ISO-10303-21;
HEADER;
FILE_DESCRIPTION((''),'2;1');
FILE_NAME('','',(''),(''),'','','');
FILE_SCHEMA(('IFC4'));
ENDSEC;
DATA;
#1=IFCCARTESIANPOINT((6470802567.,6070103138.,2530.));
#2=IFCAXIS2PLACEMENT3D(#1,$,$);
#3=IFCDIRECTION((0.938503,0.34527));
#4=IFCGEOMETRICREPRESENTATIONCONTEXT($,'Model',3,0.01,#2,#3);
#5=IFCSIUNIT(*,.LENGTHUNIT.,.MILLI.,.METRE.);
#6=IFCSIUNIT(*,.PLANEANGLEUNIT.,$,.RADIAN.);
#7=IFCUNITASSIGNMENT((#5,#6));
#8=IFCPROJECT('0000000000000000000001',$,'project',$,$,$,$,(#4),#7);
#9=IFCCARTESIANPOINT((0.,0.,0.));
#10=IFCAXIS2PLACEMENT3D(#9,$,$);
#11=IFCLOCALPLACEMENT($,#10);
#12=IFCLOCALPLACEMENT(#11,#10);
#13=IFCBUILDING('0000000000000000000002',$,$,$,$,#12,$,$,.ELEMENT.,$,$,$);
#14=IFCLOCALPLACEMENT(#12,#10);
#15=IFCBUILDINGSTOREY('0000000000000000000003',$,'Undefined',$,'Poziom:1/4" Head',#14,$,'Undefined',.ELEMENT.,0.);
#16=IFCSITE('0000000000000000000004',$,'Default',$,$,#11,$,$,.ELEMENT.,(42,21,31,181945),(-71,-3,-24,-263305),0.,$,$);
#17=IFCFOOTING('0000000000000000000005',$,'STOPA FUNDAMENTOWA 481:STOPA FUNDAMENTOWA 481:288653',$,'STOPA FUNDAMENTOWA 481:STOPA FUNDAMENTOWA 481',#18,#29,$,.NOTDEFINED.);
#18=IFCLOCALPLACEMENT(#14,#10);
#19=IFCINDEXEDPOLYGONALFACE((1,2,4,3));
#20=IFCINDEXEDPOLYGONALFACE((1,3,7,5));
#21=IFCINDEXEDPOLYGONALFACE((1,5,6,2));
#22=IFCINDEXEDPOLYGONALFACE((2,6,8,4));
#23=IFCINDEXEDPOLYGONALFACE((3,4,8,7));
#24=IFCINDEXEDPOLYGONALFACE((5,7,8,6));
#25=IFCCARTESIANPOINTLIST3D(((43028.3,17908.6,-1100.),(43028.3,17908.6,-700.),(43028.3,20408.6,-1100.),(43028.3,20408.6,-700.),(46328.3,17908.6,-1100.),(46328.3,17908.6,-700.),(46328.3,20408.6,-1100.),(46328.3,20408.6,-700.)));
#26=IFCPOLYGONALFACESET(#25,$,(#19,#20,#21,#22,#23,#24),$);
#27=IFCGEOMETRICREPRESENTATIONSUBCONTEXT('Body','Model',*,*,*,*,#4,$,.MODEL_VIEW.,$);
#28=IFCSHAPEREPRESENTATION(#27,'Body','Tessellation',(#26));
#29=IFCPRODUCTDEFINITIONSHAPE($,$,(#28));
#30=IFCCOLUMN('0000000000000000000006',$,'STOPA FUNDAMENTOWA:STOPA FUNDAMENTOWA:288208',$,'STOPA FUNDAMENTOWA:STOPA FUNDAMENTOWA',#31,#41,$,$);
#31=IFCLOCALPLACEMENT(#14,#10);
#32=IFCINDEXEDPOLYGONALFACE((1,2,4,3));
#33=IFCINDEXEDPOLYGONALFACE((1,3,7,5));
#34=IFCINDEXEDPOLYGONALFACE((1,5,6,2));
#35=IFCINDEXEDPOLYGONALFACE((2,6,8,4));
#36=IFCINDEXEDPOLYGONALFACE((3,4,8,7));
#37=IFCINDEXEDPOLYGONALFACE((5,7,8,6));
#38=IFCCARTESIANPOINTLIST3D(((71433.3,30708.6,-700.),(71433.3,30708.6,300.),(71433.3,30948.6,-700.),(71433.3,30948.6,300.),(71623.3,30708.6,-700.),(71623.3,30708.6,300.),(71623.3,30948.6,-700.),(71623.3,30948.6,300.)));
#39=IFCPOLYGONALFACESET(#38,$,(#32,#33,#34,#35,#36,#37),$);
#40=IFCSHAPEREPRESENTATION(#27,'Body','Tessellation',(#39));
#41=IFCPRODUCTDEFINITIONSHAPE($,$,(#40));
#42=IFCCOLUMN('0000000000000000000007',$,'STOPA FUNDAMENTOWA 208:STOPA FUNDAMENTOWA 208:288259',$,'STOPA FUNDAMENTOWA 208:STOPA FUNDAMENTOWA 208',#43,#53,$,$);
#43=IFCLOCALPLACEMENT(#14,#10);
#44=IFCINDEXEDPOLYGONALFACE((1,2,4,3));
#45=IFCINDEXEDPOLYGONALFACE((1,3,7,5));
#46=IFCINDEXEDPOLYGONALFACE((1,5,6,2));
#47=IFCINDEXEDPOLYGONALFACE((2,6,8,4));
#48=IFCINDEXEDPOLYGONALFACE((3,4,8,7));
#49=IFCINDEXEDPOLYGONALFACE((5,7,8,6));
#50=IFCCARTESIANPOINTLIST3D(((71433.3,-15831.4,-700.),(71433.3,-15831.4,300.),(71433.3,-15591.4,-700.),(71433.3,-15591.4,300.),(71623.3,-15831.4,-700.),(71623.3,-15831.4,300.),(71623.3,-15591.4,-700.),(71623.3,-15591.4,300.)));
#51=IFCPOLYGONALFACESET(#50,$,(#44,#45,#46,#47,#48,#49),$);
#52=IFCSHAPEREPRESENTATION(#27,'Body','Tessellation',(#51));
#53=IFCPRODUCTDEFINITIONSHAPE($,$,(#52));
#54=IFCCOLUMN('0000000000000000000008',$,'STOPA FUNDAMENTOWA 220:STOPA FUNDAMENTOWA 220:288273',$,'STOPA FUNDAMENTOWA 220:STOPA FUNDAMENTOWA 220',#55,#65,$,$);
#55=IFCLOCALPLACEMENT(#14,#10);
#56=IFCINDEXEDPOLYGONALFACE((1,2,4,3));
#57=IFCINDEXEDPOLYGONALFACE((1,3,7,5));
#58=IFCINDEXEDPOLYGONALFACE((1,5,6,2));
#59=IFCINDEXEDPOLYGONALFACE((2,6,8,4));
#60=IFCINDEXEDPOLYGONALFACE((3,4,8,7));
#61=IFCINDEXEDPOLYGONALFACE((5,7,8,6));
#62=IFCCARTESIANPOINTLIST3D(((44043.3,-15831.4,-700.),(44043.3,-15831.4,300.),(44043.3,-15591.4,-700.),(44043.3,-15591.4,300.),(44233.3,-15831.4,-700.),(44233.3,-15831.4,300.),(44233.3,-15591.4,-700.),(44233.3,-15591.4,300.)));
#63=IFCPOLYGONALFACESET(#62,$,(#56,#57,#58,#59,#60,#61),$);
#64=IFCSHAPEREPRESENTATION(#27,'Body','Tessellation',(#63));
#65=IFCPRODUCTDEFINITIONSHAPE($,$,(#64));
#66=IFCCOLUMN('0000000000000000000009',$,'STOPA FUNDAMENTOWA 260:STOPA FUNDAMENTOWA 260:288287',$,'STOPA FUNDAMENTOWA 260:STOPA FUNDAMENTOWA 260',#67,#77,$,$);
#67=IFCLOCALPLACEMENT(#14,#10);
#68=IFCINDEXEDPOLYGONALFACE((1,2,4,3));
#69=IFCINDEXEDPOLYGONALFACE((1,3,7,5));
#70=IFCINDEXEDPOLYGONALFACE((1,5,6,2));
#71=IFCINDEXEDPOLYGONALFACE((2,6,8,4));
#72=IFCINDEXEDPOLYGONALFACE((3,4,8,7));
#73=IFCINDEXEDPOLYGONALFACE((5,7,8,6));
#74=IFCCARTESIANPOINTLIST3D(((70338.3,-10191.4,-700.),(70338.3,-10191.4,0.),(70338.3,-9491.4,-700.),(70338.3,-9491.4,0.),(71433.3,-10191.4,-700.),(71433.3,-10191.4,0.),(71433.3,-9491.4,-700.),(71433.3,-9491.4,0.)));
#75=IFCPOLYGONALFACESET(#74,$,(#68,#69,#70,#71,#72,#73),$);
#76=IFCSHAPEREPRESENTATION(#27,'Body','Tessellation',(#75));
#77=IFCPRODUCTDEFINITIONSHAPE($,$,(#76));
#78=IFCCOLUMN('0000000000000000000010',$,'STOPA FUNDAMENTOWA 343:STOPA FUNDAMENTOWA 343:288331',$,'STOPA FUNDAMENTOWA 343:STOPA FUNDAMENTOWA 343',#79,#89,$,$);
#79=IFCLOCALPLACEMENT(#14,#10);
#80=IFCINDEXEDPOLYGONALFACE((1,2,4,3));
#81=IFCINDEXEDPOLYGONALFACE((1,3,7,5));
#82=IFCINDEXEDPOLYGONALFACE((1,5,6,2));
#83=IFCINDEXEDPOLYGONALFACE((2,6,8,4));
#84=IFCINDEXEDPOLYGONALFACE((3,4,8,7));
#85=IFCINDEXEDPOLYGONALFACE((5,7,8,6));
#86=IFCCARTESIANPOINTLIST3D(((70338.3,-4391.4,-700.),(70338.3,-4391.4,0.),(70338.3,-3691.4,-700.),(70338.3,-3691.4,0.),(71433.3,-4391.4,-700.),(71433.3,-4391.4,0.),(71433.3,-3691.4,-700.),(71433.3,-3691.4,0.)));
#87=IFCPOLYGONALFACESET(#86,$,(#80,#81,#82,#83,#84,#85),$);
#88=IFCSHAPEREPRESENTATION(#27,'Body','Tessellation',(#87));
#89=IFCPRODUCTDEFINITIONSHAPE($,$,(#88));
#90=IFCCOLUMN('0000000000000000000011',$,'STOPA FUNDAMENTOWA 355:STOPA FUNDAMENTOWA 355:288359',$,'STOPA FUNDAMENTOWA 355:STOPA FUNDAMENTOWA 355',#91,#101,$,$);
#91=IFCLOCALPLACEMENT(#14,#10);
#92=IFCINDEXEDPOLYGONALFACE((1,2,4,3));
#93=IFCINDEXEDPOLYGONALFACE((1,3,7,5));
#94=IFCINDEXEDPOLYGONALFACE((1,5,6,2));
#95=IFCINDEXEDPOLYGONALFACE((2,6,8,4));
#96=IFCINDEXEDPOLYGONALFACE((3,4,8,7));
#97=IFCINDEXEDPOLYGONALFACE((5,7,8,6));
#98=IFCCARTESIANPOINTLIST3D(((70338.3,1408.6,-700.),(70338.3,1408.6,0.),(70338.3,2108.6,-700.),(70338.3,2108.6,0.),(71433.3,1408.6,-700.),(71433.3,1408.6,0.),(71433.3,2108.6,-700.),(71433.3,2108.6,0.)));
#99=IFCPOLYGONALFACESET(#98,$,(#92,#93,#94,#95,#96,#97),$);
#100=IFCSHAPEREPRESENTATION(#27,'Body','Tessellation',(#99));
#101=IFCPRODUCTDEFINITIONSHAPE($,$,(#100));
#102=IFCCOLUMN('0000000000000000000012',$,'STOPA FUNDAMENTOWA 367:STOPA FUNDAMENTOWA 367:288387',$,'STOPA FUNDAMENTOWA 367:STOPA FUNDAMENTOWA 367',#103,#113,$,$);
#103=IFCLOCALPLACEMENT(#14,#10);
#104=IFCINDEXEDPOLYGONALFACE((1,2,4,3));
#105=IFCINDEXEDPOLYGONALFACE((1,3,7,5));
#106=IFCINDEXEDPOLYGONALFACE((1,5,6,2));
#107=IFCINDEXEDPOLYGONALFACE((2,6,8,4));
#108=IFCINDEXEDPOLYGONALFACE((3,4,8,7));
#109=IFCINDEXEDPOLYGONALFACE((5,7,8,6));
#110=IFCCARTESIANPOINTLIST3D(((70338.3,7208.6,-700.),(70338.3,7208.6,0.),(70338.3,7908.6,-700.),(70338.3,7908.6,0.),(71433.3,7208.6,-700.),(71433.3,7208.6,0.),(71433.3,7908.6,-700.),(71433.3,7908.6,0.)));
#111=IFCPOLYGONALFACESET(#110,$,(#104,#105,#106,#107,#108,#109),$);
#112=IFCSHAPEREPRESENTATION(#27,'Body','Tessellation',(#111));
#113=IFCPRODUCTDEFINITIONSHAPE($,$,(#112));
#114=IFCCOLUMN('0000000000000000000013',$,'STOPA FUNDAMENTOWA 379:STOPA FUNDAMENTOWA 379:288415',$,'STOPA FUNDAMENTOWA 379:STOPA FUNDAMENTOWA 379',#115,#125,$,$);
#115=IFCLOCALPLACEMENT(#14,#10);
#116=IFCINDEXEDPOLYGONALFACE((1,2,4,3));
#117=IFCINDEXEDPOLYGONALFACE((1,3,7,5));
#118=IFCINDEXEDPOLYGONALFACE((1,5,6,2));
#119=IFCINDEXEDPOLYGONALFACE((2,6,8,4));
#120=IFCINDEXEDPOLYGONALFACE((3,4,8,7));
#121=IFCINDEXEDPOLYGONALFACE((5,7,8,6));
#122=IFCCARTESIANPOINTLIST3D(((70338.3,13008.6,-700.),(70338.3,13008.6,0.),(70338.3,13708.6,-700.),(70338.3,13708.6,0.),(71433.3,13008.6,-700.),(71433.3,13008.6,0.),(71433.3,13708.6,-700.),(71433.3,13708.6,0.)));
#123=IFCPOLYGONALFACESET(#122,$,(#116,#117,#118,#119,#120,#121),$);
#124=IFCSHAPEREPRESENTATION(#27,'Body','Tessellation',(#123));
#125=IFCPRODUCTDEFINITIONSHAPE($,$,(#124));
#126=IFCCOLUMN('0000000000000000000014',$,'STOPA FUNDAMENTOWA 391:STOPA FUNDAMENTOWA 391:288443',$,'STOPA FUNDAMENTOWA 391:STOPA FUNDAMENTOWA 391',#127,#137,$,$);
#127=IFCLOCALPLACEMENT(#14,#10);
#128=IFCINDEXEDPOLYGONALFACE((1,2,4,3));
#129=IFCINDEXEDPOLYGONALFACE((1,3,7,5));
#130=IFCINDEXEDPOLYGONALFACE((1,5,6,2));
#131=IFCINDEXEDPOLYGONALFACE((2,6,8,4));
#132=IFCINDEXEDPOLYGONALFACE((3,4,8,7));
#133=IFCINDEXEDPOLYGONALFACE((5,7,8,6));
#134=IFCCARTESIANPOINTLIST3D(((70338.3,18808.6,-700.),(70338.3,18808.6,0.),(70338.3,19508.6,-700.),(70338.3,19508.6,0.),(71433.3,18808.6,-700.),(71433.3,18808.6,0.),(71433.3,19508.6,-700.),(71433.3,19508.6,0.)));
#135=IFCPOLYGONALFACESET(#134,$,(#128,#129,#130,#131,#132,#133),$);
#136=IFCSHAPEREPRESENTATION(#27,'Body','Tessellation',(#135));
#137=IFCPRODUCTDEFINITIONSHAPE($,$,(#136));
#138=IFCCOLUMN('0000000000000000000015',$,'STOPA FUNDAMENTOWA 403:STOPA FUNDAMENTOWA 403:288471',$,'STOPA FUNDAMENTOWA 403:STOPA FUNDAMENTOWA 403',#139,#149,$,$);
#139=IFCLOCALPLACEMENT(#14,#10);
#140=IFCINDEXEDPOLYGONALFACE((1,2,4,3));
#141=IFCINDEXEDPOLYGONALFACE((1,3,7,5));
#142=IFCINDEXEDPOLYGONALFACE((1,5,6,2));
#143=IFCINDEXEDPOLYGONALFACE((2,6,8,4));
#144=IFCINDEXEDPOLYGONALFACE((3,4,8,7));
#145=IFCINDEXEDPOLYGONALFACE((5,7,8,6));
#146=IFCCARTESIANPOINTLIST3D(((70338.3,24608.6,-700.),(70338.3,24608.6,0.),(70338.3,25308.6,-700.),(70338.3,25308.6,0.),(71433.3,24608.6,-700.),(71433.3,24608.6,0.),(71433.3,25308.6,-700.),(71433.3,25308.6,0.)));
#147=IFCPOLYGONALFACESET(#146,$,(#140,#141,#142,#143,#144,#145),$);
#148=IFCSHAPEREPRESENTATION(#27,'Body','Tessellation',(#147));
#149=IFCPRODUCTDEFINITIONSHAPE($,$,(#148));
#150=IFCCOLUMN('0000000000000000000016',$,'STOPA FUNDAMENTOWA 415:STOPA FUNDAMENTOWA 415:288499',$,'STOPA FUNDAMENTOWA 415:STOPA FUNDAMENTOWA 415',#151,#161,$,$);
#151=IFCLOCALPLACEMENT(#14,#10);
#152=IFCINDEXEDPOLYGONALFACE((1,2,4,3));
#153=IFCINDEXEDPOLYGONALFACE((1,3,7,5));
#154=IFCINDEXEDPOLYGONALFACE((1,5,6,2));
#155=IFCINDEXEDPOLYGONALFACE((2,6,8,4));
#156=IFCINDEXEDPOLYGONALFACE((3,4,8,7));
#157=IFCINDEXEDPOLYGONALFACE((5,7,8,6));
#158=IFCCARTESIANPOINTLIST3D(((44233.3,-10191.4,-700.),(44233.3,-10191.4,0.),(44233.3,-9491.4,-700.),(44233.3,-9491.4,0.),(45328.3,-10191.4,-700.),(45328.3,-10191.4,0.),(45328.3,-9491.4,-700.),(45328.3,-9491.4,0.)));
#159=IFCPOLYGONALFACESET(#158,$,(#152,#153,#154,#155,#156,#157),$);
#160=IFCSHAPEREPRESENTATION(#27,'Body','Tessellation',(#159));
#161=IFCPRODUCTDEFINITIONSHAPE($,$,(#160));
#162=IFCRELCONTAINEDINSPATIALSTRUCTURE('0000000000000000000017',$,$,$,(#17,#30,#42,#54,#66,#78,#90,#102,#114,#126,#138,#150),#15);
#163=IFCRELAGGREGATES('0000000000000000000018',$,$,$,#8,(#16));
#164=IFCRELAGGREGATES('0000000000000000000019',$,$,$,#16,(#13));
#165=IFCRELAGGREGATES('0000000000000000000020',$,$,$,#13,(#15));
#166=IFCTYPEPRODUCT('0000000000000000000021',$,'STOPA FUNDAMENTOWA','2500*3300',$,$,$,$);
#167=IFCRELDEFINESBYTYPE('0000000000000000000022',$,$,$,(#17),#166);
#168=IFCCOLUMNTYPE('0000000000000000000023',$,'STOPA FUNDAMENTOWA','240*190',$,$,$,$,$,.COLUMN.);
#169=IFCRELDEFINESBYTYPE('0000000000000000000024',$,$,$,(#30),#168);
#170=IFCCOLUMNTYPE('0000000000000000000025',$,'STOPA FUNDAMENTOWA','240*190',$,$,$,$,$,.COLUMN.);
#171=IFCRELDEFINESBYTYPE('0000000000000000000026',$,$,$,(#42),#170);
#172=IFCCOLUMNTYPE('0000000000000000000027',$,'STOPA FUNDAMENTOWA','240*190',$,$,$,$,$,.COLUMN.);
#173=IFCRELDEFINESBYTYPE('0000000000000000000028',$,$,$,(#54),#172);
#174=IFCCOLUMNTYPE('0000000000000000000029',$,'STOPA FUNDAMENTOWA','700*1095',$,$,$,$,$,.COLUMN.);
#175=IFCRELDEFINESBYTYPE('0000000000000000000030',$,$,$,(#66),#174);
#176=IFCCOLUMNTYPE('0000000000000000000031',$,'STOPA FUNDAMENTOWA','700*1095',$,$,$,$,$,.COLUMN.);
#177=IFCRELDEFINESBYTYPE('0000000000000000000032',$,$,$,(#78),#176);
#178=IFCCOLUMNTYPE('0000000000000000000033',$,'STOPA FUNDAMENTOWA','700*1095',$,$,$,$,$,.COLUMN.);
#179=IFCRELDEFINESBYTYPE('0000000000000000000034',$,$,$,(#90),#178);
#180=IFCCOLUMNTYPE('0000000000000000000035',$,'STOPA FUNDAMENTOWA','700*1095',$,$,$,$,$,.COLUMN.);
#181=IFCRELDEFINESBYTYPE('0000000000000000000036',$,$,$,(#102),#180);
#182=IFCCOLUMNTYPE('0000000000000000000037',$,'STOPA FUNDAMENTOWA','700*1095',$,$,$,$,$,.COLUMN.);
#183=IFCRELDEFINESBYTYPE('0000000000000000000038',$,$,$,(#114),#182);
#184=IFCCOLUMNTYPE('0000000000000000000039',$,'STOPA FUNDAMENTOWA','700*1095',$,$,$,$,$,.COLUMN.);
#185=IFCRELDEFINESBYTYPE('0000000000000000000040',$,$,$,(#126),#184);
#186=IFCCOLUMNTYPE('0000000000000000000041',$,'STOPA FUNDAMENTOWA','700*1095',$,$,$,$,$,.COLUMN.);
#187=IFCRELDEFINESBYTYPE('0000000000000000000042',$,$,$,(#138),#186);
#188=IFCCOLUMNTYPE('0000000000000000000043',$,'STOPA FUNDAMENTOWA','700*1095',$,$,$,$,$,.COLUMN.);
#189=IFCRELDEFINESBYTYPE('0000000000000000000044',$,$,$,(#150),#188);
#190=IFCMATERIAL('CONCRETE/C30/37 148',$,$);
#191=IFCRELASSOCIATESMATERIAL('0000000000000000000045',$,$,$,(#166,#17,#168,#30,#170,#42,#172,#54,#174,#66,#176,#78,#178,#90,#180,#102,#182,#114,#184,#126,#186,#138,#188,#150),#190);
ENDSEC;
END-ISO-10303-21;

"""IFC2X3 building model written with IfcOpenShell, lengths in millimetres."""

from ifc_helpers import new_model, si_unit, direction, frame, frame_2d, origin, origin_2d_with_axis, place, context, subcontext, project, spatial, rectangle, extrude, source, transform, mapped, material, type_object, type_shapes, element, save


model = new_model("IFC2X3")

# Units and contexts
model_context = context("Model", 3, precision=0.01, world=frame((6470802567.0, 6070103138.0, 2530.0)), true_north=direction((0.938503, 0.34527)))
body_context = subcontext(model_context, "Body", "Model", "MODEL_VIEW")
ifc_project = project(units=[si_unit("LENGTHUNIT", "METRE", prefix="MILLI"), si_unit("PLANEANGLEUNIT", "RADIAN")], contexts=[model_context])

# Site, building, storey
site_placement = place(None, origin())
site = spatial("IfcSite", under=ifc_project, at=site_placement, Name="Default", CompositionType="ELEMENT", RefLatitude=(42, 21, 31, 181945), RefLongitude=(-71, -3, -24, -263305), RefElevation=0.0)
building_placement = place(site_placement, origin())
building = spatial("IfcBuilding", under=site, at=building_placement, CompositionType="ELEMENT")
storey_placement = place(building_placement, origin())
storey = spatial("IfcBuildingStorey", under=building, at=storey_placement, Name="Undefined", ObjectType="Poziom:1/4\" Head", LongName="Undefined", CompositionType="ELEMENT", Elevation=0.0)

# Footing
ifc_material = material(Name="CONCRETE/C30/37 148")
type_product_1 = type_object("IfcTypeProduct", Name="STOPA FUNDAMENTOWA", Description="2500*3300", material=ifc_material)
shared_shape_1 = source(origin(), body_context, "Body", "SweptSolid", [
    extrude(rectangle(XDim=2500.0, YDim=3300.0, at=origin_2d_with_axis()), frame((44678.3, 19158.6, -1100.0), z_axis=(0.0, 0.0, 1.0), x_axis=(0.0, -1.0, 0.0)), (0.0, 0.0, 1.0), 400.0),
])
type_shapes(type_product_1, [shared_shape_1])
footing_1_placement = place(storey_placement, origin())
element("IfcFooting", 1, at=footing_1_placement, inside=storey, type_object=type_product_1, material=ifc_material, Name="STOPA FUNDAMENTOWA 481:STOPA FUNDAMENTOWA 481:288653", ObjectType="STOPA FUNDAMENTOWA 481:STOPA FUNDAMENTOWA 481", PredefinedType="NOTDEFINED", context=body_context, shape_type="MappedRepresentation", body=[
    mapped(shared_shape_1, transform((0.0, 0.0, 0.0), scale=1.0)),
])

# Columns
column_type_1 = type_object("IfcColumnType", Name="STOPA FUNDAMENTOWA", Description="240*190", PredefinedType="COLUMN", material=ifc_material)
shared_shape_2 = source(origin(), body_context, "Body", "SweptSolid", [
    extrude(rectangle(XDim=240.0, YDim=190.0, at=frame_2d((0.0, 0.0), x_axis=(1.0, 0.0))), frame((71528.3, 30828.6, -700.0), z_axis=(0.0, 0.0, 1.0), x_axis=(0.0, -1.0, 0.0)), (0.0, 0.0, 1.0), 1000.0),
])
type_shapes(column_type_1, [shared_shape_2])
column_1_placement = place(storey_placement, origin())
element("IfcColumn", 2, at=column_1_placement, inside=storey, type_object=column_type_1, material=ifc_material, Name="STOPA FUNDAMENTOWA:STOPA FUNDAMENTOWA:288208", ObjectType="STOPA FUNDAMENTOWA:STOPA FUNDAMENTOWA", context=body_context, shape_type="MappedRepresentation", body=[
    mapped(shared_shape_2, transform((0.0, 0.0, 0.0), scale=1.0)),
])
column_type_2 = type_object("IfcColumnType", Name="STOPA FUNDAMENTOWA", Description="240*190", PredefinedType="COLUMN", material=ifc_material)
shared_shape_3 = source(origin(), body_context, "Body", "SweptSolid", [
    extrude(rectangle(XDim=240.0, YDim=190.0, at=frame_2d((0.0, 0.0), x_axis=(1.0, 0.0))), frame((71528.3, -15711.4, -700.0), z_axis=(0.0, 0.0, 1.0), x_axis=(0.0, -1.0, 0.0)), (0.0, 0.0, 1.0), 1000.0),
])
type_shapes(column_type_2, [shared_shape_3])
column_2_placement = place(storey_placement, origin())
element("IfcColumn", 3, at=column_2_placement, inside=storey, type_object=column_type_2, material=ifc_material, Name="STOPA FUNDAMENTOWA 208:STOPA FUNDAMENTOWA 208:288259", ObjectType="STOPA FUNDAMENTOWA 208:STOPA FUNDAMENTOWA 208", context=body_context, shape_type="MappedRepresentation", body=[
    mapped(shared_shape_3, transform((0.0, 0.0, 0.0), scale=1.0)),
])
column_type_3 = type_object("IfcColumnType", Name="STOPA FUNDAMENTOWA", Description="240*190", PredefinedType="COLUMN", material=ifc_material)
shared_shape_4 = source(origin(), body_context, "Body", "SweptSolid", [
    extrude(rectangle(XDim=240.0, YDim=190.0, at=frame_2d((0.0, 0.0), x_axis=(1.0, 0.0))), frame((44138.3, -15711.4, -700.0), z_axis=(0.0, 0.0, 1.0), x_axis=(0.0, 1.0, 0.0)), (0.0, 0.0, 1.0), 1000.0),
])
type_shapes(column_type_3, [shared_shape_4])
column_3_placement = place(storey_placement, origin())
element("IfcColumn", 4, at=column_3_placement, inside=storey, type_object=column_type_3, material=ifc_material, Name="STOPA FUNDAMENTOWA 220:STOPA FUNDAMENTOWA 220:288273", ObjectType="STOPA FUNDAMENTOWA 220:STOPA FUNDAMENTOWA 220", context=body_context, shape_type="MappedRepresentation", body=[
    mapped(shared_shape_4, transform((0.0, 0.0, 0.0), scale=1.0)),
])
column_type_4 = type_object("IfcColumnType", Name="STOPA FUNDAMENTOWA", Description="700*1095", PredefinedType="COLUMN", material=ifc_material)
shared_shape_5 = source(origin(), body_context, "Body", "SweptSolid", [
    extrude(rectangle(XDim=700.0, YDim=1095.0, at=frame_2d((0.0, 0.0), x_axis=(1.0, 0.0))), frame((70885.8, -9841.4, -700.0), z_axis=(0.0, 0.0, 1.0), x_axis=(0.0, -1.0, 0.0)), (0.0, 0.0, 1.0), 700.0),
])
type_shapes(column_type_4, [shared_shape_5])
column_4_placement = place(storey_placement, origin())
element("IfcColumn", 5, at=column_4_placement, inside=storey, type_object=column_type_4, material=ifc_material, Name="STOPA FUNDAMENTOWA 260:STOPA FUNDAMENTOWA 260:288287", ObjectType="STOPA FUNDAMENTOWA 260:STOPA FUNDAMENTOWA 260", context=body_context, shape_type="MappedRepresentation", body=[
    mapped(shared_shape_5, transform((0.0, 0.0, 0.0), scale=1.0)),
])
column_type_5 = type_object("IfcColumnType", Name="STOPA FUNDAMENTOWA", Description="700*1095", PredefinedType="COLUMN", material=ifc_material)
shared_shape_6 = source(origin(), body_context, "Body", "SweptSolid", [
    extrude(rectangle(XDim=700.0, YDim=1095.0, at=frame_2d((0.0, 0.0), x_axis=(1.0, 0.0))), frame((70885.8, -4041.4, -700.0), z_axis=(0.0, 0.0, 1.0), x_axis=(0.0, -1.0, 0.0)), (0.0, 0.0, 1.0), 700.0),
])
type_shapes(column_type_5, [shared_shape_6])
column_5_placement = place(storey_placement, origin())
element("IfcColumn", 6, at=column_5_placement, inside=storey, type_object=column_type_5, material=ifc_material, Name="STOPA FUNDAMENTOWA 343:STOPA FUNDAMENTOWA 343:288331", ObjectType="STOPA FUNDAMENTOWA 343:STOPA FUNDAMENTOWA 343", context=body_context, shape_type="MappedRepresentation", body=[
    mapped(shared_shape_6, transform((0.0, 0.0, 0.0), scale=1.0)),
])
column_type_6 = type_object("IfcColumnType", Name="STOPA FUNDAMENTOWA", Description="700*1095", PredefinedType="COLUMN", material=ifc_material)
shared_shape_7 = source(origin(), body_context, "Body", "SweptSolid", [
    extrude(rectangle(XDim=700.0, YDim=1095.0, at=frame_2d((0.0, 0.0), x_axis=(1.0, 0.0))), frame((70885.8, 1758.6, -700.0), z_axis=(0.0, 0.0, 1.0), x_axis=(0.0, -1.0, 0.0)), (0.0, 0.0, 1.0), 700.0),
])
type_shapes(column_type_6, [shared_shape_7])
column_6_placement = place(storey_placement, origin())
element("IfcColumn", 7, at=column_6_placement, inside=storey, type_object=column_type_6, material=ifc_material, Name="STOPA FUNDAMENTOWA 355:STOPA FUNDAMENTOWA 355:288359", ObjectType="STOPA FUNDAMENTOWA 355:STOPA FUNDAMENTOWA 355", context=body_context, shape_type="MappedRepresentation", body=[
    mapped(shared_shape_7, transform((0.0, 0.0, 0.0), scale=1.0)),
])
column_type_7 = type_object("IfcColumnType", Name="STOPA FUNDAMENTOWA", Description="700*1095", PredefinedType="COLUMN", material=ifc_material)
shared_shape_8 = source(origin(), body_context, "Body", "SweptSolid", [
    extrude(rectangle(XDim=700.0, YDim=1095.0, at=frame_2d((0.0, 0.0), x_axis=(1.0, 0.0))), frame((70885.8, 7558.6, -700.0), z_axis=(0.0, 0.0, 1.0), x_axis=(0.0, -1.0, 0.0)), (0.0, 0.0, 1.0), 700.0),
])
type_shapes(column_type_7, [shared_shape_8])
column_7_placement = place(storey_placement, origin())
element("IfcColumn", 8, at=column_7_placement, inside=storey, type_object=column_type_7, material=ifc_material, Name="STOPA FUNDAMENTOWA 367:STOPA FUNDAMENTOWA 367:288387", ObjectType="STOPA FUNDAMENTOWA 367:STOPA FUNDAMENTOWA 367", context=body_context, shape_type="MappedRepresentation", body=[
    mapped(shared_shape_8, transform((0.0, 0.0, 0.0), scale=1.0)),
])
column_type_8 = type_object("IfcColumnType", Name="STOPA FUNDAMENTOWA", Description="700*1095", PredefinedType="COLUMN", material=ifc_material)
shared_shape_9 = source(origin(), body_context, "Body", "SweptSolid", [
    extrude(rectangle(XDim=700.0, YDim=1095.0, at=frame_2d((0.0, 0.0), x_axis=(1.0, 0.0))), frame((70885.8, 13358.6, -700.0), z_axis=(0.0, 0.0, 1.0), x_axis=(0.0, -1.0, 0.0)), (0.0, 0.0, 1.0), 700.0),
])
type_shapes(column_type_8, [shared_shape_9])
column_8_placement = place(storey_placement, origin())
element("IfcColumn", 9, at=column_8_placement, inside=storey, type_object=column_type_8, material=ifc_material, Name="STOPA FUNDAMENTOWA 379:STOPA FUNDAMENTOWA 379:288415", ObjectType="STOPA FUNDAMENTOWA 379:STOPA FUNDAMENTOWA 379", context=body_context, shape_type="MappedRepresentation", body=[
    mapped(shared_shape_9, transform((0.0, 0.0, 0.0), scale=1.0)),
])
column_type_9 = type_object("IfcColumnType", Name="STOPA FUNDAMENTOWA", Description="700*1095", PredefinedType="COLUMN", material=ifc_material)
shared_shape_10 = source(origin(), body_context, "Body", "SweptSolid", [
    extrude(rectangle(XDim=700.0, YDim=1095.0, at=frame_2d((0.0, 0.0), x_axis=(1.0, 0.0))), frame((70885.8, 19158.6, -700.0), z_axis=(0.0, 0.0, 1.0), x_axis=(0.0, -1.0, 0.0)), (0.0, 0.0, 1.0), 700.0),
])
type_shapes(column_type_9, [shared_shape_10])
column_9_placement = place(storey_placement, origin())
element("IfcColumn", 10, at=column_9_placement, inside=storey, type_object=column_type_9, material=ifc_material, Name="STOPA FUNDAMENTOWA 391:STOPA FUNDAMENTOWA 391:288443", ObjectType="STOPA FUNDAMENTOWA 391:STOPA FUNDAMENTOWA 391", context=body_context, shape_type="MappedRepresentation", body=[
    mapped(shared_shape_10, transform((0.0, 0.0, 0.0), scale=1.0)),
])
column_type_10 = type_object("IfcColumnType", Name="STOPA FUNDAMENTOWA", Description="700*1095", PredefinedType="COLUMN", material=ifc_material)
shared_shape_11 = source(origin(), body_context, "Body", "SweptSolid", [
    extrude(rectangle(XDim=700.0, YDim=1095.0, at=frame_2d((0.0, 0.0), x_axis=(1.0, 0.0))), frame((70885.8, 24958.6, -700.0), z_axis=(0.0, 0.0, 1.0), x_axis=(0.0, -1.0, 0.0)), (0.0, 0.0, 1.0), 700.0),
])
type_shapes(column_type_10, [shared_shape_11])
column_10_placement = place(storey_placement, origin())
element("IfcColumn", 11, at=column_10_placement, inside=storey, type_object=column_type_10, material=ifc_material, Name="STOPA FUNDAMENTOWA 403:STOPA FUNDAMENTOWA 403:288471", ObjectType="STOPA FUNDAMENTOWA 403:STOPA FUNDAMENTOWA 403", context=body_context, shape_type="MappedRepresentation", body=[
    mapped(shared_shape_11, transform((0.0, 0.0, 0.0), scale=1.0)),
])
column_type_11 = type_object("IfcColumnType", Name="STOPA FUNDAMENTOWA", Description="700*1095", PredefinedType="COLUMN", material=ifc_material)
shared_shape_12 = source(origin(), body_context, "Body", "SweptSolid", [
    extrude(rectangle(XDim=700.0, YDim=1095.0, at=frame_2d((0.0, 0.0), x_axis=(1.0, 0.0))), frame((44780.8, -9841.4, -700.0), z_axis=(0.0, 0.0, 1.0), x_axis=(0.0, 1.0, 0.0)), (0.0, 0.0, 1.0), 700.0),
])
type_shapes(column_type_11, [shared_shape_12])
column_11_placement = place(storey_placement, origin())
element("IfcColumn", 12, at=column_11_placement, inside=storey, type_object=column_type_11, material=ifc_material, Name="STOPA FUNDAMENTOWA 415:STOPA FUNDAMENTOWA 415:288499", ObjectType="STOPA FUNDAMENTOWA 415:STOPA FUNDAMENTOWA 415", context=body_context, shape_type="MappedRepresentation", body=[
    mapped(shared_shape_12, transform((0.0, 0.0, 0.0), scale=1.0)),
])

save(model, "model.ifc")
